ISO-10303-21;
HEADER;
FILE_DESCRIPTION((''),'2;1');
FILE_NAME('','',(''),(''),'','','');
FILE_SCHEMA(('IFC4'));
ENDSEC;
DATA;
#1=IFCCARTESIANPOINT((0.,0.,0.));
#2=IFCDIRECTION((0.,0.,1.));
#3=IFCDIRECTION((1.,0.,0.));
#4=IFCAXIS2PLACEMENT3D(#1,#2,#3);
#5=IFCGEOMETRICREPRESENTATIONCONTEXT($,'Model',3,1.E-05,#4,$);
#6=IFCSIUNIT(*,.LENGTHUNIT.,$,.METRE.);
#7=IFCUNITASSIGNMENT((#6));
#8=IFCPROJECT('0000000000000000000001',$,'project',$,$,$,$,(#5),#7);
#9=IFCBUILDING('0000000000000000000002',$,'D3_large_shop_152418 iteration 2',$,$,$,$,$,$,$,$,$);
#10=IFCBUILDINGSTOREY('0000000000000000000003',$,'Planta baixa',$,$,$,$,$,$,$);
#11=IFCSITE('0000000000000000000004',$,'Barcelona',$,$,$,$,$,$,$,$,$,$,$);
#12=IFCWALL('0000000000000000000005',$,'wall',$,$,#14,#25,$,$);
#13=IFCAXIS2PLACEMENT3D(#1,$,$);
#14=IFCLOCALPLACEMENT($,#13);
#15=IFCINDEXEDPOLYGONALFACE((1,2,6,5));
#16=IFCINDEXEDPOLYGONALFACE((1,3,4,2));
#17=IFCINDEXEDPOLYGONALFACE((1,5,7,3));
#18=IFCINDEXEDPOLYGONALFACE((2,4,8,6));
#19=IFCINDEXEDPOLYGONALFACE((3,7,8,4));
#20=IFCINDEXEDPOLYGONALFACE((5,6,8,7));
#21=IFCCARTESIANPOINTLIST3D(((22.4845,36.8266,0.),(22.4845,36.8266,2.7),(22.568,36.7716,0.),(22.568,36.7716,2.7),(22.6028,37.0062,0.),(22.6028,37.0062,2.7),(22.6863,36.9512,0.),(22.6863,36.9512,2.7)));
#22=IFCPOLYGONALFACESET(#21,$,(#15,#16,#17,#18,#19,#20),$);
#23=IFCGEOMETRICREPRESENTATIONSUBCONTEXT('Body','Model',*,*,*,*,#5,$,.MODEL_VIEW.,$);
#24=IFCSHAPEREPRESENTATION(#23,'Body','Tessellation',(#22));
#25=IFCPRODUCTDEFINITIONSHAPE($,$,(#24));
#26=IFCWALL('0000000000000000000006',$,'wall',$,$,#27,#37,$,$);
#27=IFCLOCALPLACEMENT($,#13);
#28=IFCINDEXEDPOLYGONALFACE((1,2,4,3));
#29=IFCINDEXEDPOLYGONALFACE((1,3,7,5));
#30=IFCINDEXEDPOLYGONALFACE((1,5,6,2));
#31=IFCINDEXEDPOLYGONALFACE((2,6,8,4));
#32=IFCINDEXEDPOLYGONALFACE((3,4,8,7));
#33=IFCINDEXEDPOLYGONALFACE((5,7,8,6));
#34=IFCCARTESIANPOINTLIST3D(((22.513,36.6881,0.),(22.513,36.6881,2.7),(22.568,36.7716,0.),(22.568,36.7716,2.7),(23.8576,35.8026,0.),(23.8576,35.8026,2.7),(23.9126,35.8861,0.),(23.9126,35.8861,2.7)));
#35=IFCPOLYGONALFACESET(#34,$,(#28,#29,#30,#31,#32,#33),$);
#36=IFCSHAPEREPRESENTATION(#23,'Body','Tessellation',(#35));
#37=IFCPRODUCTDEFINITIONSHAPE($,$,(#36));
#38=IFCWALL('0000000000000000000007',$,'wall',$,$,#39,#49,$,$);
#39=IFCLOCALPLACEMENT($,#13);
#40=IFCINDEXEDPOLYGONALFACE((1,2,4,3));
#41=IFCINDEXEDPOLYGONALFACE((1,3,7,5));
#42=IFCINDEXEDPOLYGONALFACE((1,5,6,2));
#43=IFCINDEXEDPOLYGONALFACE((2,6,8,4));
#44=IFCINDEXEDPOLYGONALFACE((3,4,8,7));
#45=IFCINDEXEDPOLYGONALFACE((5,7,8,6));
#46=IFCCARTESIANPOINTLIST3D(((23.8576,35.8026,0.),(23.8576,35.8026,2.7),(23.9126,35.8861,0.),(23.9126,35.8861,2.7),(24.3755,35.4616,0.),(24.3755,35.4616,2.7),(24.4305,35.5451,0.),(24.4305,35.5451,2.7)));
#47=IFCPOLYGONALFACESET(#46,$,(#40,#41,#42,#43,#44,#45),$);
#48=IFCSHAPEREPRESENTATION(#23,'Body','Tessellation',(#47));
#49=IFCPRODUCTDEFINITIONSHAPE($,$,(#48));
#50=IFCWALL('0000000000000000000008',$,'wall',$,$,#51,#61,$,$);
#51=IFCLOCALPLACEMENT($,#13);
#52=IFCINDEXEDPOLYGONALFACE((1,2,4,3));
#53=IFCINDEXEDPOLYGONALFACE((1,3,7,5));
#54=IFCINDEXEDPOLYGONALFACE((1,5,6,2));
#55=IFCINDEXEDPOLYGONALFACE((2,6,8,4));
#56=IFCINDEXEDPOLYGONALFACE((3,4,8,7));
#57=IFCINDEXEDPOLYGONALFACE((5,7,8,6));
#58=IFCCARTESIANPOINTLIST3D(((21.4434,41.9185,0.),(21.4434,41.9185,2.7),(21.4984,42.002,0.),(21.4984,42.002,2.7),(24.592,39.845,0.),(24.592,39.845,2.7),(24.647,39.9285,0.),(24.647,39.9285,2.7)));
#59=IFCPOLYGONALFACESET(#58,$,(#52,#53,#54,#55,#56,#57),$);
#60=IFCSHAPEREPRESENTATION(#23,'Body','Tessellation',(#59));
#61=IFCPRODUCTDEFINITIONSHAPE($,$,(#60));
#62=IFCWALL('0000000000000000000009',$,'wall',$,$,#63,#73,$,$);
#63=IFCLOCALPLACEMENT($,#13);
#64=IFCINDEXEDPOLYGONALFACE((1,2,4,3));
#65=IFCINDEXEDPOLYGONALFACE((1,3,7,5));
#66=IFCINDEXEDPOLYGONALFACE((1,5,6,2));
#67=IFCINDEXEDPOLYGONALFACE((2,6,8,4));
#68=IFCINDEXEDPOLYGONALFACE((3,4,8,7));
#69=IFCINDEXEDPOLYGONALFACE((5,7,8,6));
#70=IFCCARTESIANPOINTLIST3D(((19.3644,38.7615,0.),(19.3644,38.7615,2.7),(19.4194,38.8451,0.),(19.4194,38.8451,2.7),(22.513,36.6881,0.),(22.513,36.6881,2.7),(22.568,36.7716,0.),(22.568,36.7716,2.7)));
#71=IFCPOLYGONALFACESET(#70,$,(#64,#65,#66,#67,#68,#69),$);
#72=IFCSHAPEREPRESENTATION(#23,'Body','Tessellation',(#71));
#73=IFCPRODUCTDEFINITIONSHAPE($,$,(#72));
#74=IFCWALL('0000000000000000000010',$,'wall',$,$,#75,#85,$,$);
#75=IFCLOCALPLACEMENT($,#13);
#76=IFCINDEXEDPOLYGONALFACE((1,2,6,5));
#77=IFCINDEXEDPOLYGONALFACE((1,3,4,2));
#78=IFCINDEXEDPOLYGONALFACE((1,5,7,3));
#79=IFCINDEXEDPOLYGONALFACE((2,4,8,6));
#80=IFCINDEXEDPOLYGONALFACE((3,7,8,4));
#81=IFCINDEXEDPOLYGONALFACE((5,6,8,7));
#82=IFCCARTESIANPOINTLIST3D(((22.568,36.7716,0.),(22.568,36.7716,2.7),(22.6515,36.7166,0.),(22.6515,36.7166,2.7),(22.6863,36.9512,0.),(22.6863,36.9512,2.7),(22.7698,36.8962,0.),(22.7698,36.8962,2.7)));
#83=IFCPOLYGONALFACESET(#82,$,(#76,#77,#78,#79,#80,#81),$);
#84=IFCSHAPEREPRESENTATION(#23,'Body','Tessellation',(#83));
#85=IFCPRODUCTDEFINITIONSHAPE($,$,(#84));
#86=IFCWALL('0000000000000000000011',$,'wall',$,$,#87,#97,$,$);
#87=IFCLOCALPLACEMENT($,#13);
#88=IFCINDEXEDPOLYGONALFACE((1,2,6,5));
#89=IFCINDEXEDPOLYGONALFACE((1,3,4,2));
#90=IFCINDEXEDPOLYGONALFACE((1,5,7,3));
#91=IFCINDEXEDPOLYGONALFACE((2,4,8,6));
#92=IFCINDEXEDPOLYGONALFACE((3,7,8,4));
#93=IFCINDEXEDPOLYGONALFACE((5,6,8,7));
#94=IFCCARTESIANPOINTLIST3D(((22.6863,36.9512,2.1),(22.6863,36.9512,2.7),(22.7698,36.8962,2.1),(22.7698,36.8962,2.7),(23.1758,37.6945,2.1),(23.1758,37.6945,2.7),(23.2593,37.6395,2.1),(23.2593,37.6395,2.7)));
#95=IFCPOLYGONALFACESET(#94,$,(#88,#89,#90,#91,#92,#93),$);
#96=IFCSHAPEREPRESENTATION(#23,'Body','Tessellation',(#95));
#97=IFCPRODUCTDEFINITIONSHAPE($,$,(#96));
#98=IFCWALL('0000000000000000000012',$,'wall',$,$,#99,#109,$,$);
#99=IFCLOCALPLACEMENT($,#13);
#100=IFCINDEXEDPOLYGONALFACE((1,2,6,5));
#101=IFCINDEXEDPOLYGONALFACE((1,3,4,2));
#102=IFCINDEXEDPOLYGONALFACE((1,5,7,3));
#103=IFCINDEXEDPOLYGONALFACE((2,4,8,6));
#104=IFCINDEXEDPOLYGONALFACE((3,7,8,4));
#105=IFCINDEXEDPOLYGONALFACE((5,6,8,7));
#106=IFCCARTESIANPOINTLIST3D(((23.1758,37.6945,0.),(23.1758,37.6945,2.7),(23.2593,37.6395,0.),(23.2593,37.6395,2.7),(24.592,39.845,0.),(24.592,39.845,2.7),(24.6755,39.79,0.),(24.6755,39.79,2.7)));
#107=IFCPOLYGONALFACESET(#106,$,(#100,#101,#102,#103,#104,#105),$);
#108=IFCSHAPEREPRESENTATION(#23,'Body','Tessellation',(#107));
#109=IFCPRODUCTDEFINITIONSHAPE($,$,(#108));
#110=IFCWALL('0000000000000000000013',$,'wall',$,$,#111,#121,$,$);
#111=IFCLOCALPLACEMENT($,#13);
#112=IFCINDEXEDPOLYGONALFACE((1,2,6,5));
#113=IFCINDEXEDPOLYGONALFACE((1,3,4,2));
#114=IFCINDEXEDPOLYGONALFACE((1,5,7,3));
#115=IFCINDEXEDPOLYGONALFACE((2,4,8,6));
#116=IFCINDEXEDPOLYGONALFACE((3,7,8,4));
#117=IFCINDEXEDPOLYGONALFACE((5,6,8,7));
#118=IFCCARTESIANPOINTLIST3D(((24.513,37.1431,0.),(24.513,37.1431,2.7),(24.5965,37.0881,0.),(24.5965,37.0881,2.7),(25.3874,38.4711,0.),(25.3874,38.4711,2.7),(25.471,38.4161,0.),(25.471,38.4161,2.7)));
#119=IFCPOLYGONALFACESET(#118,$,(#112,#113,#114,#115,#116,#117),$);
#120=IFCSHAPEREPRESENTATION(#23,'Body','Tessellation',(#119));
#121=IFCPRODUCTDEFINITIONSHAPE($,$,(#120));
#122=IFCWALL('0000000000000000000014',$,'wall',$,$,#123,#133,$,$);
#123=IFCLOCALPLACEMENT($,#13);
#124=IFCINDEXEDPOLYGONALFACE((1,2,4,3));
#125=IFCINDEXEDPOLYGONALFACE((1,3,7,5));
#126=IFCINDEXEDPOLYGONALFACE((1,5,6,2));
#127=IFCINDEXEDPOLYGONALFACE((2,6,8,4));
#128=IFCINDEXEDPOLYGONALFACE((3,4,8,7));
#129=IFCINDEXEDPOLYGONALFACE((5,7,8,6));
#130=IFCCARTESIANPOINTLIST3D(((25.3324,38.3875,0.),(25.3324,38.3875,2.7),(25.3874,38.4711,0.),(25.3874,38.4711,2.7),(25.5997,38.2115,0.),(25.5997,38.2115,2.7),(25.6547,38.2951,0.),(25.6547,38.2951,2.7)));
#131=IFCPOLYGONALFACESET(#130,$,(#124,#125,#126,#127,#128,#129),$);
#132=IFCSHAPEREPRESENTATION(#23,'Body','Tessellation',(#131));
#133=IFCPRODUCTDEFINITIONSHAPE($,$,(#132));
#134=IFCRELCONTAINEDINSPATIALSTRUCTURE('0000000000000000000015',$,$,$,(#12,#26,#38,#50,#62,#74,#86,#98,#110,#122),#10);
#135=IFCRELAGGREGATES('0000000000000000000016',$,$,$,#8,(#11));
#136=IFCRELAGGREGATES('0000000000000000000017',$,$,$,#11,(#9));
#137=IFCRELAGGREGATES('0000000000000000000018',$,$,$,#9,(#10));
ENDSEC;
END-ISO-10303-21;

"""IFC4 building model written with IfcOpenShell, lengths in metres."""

from ifc_helpers import new_model, si_unit, frame, origin, origin_with_axes, place, context, subcontext, project, spatial, polyline, outline, extrude, element, save


model = new_model("IFC4")

# Units and contexts
model_context = context("Model", 3, precision=1e-05, world=origin_with_axes())
body_context = subcontext(model_context, "Body", "Model", "MODEL_VIEW")
ifc_project = project(units=[si_unit("LENGTHUNIT", "METRE")], contexts=[model_context])

# Site, building, storey
site = spatial("IfcSite", under=ifc_project, Name="Barcelona")
building = spatial("IfcBuilding", under=site, Name="D3_large_shop_152418 iteration 2")
storey = spatial("IfcBuildingStorey", under=building, Name="Planta baixa")

# Walls
wall_1_placement = place(None, origin_with_axes())
element("IfcWall", 1, at=wall_1_placement, inside=storey, Name="wall", context=body_context, shape_type="SweptSolid", body=[
    extrude(outline(polyline([(22.6863, 36.9512), (22.568, 36.7716), (22.4845, 36.8266), (22.6028, 37.0062), (22.6863, 36.9512)])), origin(), (0.0, 0.0, 1.0), 2.7),
])
wall_2_placement = place(None, origin_with_axes())
element("IfcWall", 2, at=wall_2_placement, inside=storey, Name="wall", context=body_context, shape_type="SweptSolid", body=[
    extrude(outline(polyline([(22.568, 36.7716), (23.9126, 35.8861), (23.8576, 35.8026), (22.513, 36.6881), (22.568, 36.7716)])), origin(), (0.0, 0.0, 1.0), 2.7),
])
wall_3_placement = place(None, origin_with_axes())
element("IfcWall", 3, at=wall_3_placement, inside=storey, Name="wall", context=body_context, shape_type="SweptSolid", body=[
    extrude(outline(polyline([(23.9126, 35.8861), (24.4305, 35.5451), (24.3755, 35.4616), (23.8576, 35.8026), (23.9126, 35.8861)])), origin(), (0.0, 0.0, 1.0), 2.7),
])
wall_4_placement = place(None, origin_with_axes())
element("IfcWall", 4, at=wall_4_placement, inside=storey, Name="wall", context=body_context, shape_type="SweptSolid", body=[
    extrude(outline(polyline([(24.592, 39.845), (21.4434, 41.9185), (21.4984, 42.002), (24.647, 39.9285), (24.592, 39.845)])), origin(), (0.0, 0.0, 1.0), 2.7),
])
wall_5_placement = place(None, origin_with_axes())
element("IfcWall", 5, at=wall_5_placement, inside=storey, Name="wall", context=body_context, shape_type="SweptSolid", body=[
    extrude(outline(polyline([(19.4194, 38.8451), (22.568, 36.7716), (22.513, 36.6881), (19.3644, 38.7615), (19.4194, 38.8451)])), origin(), (0.0, 0.0, 1.0), 2.7),
])
wall_6_placement = place(None, origin_with_axes())
element("IfcWall", 6, at=wall_6_placement, inside=storey, Name="wall", context=body_context, shape_type="SweptSolid", body=[
    extrude(outline(polyline([(22.568, 36.7716), (22.6863, 36.9512), (22.7698, 36.8962), (22.6515, 36.7166), (22.568, 36.7716)])), origin(), (0.0, 0.0, 1.0), 2.7),
])
wall_7_placement = place(None, origin_with_axes())
element("IfcWall", 7, at=wall_7_placement, inside=storey, Name="wall", context=body_context, shape_type="SweptSolid", body=[
    extrude(outline(polyline([(22.6863, 36.9512), (23.1758, 37.6945), (23.2593, 37.6395), (22.7698, 36.8962), (22.6863, 36.9512)])), frame((0.0, 0.0, 2.1)), (0.0, 0.0, 1.0), 0.6),
])
wall_8_placement = place(None, origin_with_axes())
element("IfcWall", 8, at=wall_8_placement, inside=storey, Name="wall", context=body_context, shape_type="SweptSolid", body=[
    extrude(outline(polyline([(23.1758, 37.6945), (24.592, 39.845), (24.6755, 39.79), (23.2593, 37.6395), (23.1758, 37.6945)])), origin(), (0.0, 0.0, 1.0), 2.7),
])
wall_9_placement = place(None, origin_with_axes())
element("IfcWall", 9, at=wall_9_placement, inside=storey, Name="wall", context=body_context, shape_type="SweptSolid", body=[
    extrude(outline(polyline([(24.513, 37.1431), (25.3874, 38.4711), (25.471, 38.4161), (24.5965, 37.0881), (24.513, 37.1431)])), origin(), (0.0, 0.0, 1.0), 2.7),
])
wall_10_placement = place(None, origin_with_axes())
element("IfcWall", 10, at=wall_10_placement, inside=storey, Name="wall", context=body_context, shape_type="SweptSolid", body=[
    extrude(outline(polyline([(25.3874, 38.4711), (25.6547, 38.2951), (25.5997, 38.2115), (25.3324, 38.3875), (25.3874, 38.4711)])), origin(), (0.0, 0.0, 1.0), 2.7),
])

save(model, "model.ifc")
